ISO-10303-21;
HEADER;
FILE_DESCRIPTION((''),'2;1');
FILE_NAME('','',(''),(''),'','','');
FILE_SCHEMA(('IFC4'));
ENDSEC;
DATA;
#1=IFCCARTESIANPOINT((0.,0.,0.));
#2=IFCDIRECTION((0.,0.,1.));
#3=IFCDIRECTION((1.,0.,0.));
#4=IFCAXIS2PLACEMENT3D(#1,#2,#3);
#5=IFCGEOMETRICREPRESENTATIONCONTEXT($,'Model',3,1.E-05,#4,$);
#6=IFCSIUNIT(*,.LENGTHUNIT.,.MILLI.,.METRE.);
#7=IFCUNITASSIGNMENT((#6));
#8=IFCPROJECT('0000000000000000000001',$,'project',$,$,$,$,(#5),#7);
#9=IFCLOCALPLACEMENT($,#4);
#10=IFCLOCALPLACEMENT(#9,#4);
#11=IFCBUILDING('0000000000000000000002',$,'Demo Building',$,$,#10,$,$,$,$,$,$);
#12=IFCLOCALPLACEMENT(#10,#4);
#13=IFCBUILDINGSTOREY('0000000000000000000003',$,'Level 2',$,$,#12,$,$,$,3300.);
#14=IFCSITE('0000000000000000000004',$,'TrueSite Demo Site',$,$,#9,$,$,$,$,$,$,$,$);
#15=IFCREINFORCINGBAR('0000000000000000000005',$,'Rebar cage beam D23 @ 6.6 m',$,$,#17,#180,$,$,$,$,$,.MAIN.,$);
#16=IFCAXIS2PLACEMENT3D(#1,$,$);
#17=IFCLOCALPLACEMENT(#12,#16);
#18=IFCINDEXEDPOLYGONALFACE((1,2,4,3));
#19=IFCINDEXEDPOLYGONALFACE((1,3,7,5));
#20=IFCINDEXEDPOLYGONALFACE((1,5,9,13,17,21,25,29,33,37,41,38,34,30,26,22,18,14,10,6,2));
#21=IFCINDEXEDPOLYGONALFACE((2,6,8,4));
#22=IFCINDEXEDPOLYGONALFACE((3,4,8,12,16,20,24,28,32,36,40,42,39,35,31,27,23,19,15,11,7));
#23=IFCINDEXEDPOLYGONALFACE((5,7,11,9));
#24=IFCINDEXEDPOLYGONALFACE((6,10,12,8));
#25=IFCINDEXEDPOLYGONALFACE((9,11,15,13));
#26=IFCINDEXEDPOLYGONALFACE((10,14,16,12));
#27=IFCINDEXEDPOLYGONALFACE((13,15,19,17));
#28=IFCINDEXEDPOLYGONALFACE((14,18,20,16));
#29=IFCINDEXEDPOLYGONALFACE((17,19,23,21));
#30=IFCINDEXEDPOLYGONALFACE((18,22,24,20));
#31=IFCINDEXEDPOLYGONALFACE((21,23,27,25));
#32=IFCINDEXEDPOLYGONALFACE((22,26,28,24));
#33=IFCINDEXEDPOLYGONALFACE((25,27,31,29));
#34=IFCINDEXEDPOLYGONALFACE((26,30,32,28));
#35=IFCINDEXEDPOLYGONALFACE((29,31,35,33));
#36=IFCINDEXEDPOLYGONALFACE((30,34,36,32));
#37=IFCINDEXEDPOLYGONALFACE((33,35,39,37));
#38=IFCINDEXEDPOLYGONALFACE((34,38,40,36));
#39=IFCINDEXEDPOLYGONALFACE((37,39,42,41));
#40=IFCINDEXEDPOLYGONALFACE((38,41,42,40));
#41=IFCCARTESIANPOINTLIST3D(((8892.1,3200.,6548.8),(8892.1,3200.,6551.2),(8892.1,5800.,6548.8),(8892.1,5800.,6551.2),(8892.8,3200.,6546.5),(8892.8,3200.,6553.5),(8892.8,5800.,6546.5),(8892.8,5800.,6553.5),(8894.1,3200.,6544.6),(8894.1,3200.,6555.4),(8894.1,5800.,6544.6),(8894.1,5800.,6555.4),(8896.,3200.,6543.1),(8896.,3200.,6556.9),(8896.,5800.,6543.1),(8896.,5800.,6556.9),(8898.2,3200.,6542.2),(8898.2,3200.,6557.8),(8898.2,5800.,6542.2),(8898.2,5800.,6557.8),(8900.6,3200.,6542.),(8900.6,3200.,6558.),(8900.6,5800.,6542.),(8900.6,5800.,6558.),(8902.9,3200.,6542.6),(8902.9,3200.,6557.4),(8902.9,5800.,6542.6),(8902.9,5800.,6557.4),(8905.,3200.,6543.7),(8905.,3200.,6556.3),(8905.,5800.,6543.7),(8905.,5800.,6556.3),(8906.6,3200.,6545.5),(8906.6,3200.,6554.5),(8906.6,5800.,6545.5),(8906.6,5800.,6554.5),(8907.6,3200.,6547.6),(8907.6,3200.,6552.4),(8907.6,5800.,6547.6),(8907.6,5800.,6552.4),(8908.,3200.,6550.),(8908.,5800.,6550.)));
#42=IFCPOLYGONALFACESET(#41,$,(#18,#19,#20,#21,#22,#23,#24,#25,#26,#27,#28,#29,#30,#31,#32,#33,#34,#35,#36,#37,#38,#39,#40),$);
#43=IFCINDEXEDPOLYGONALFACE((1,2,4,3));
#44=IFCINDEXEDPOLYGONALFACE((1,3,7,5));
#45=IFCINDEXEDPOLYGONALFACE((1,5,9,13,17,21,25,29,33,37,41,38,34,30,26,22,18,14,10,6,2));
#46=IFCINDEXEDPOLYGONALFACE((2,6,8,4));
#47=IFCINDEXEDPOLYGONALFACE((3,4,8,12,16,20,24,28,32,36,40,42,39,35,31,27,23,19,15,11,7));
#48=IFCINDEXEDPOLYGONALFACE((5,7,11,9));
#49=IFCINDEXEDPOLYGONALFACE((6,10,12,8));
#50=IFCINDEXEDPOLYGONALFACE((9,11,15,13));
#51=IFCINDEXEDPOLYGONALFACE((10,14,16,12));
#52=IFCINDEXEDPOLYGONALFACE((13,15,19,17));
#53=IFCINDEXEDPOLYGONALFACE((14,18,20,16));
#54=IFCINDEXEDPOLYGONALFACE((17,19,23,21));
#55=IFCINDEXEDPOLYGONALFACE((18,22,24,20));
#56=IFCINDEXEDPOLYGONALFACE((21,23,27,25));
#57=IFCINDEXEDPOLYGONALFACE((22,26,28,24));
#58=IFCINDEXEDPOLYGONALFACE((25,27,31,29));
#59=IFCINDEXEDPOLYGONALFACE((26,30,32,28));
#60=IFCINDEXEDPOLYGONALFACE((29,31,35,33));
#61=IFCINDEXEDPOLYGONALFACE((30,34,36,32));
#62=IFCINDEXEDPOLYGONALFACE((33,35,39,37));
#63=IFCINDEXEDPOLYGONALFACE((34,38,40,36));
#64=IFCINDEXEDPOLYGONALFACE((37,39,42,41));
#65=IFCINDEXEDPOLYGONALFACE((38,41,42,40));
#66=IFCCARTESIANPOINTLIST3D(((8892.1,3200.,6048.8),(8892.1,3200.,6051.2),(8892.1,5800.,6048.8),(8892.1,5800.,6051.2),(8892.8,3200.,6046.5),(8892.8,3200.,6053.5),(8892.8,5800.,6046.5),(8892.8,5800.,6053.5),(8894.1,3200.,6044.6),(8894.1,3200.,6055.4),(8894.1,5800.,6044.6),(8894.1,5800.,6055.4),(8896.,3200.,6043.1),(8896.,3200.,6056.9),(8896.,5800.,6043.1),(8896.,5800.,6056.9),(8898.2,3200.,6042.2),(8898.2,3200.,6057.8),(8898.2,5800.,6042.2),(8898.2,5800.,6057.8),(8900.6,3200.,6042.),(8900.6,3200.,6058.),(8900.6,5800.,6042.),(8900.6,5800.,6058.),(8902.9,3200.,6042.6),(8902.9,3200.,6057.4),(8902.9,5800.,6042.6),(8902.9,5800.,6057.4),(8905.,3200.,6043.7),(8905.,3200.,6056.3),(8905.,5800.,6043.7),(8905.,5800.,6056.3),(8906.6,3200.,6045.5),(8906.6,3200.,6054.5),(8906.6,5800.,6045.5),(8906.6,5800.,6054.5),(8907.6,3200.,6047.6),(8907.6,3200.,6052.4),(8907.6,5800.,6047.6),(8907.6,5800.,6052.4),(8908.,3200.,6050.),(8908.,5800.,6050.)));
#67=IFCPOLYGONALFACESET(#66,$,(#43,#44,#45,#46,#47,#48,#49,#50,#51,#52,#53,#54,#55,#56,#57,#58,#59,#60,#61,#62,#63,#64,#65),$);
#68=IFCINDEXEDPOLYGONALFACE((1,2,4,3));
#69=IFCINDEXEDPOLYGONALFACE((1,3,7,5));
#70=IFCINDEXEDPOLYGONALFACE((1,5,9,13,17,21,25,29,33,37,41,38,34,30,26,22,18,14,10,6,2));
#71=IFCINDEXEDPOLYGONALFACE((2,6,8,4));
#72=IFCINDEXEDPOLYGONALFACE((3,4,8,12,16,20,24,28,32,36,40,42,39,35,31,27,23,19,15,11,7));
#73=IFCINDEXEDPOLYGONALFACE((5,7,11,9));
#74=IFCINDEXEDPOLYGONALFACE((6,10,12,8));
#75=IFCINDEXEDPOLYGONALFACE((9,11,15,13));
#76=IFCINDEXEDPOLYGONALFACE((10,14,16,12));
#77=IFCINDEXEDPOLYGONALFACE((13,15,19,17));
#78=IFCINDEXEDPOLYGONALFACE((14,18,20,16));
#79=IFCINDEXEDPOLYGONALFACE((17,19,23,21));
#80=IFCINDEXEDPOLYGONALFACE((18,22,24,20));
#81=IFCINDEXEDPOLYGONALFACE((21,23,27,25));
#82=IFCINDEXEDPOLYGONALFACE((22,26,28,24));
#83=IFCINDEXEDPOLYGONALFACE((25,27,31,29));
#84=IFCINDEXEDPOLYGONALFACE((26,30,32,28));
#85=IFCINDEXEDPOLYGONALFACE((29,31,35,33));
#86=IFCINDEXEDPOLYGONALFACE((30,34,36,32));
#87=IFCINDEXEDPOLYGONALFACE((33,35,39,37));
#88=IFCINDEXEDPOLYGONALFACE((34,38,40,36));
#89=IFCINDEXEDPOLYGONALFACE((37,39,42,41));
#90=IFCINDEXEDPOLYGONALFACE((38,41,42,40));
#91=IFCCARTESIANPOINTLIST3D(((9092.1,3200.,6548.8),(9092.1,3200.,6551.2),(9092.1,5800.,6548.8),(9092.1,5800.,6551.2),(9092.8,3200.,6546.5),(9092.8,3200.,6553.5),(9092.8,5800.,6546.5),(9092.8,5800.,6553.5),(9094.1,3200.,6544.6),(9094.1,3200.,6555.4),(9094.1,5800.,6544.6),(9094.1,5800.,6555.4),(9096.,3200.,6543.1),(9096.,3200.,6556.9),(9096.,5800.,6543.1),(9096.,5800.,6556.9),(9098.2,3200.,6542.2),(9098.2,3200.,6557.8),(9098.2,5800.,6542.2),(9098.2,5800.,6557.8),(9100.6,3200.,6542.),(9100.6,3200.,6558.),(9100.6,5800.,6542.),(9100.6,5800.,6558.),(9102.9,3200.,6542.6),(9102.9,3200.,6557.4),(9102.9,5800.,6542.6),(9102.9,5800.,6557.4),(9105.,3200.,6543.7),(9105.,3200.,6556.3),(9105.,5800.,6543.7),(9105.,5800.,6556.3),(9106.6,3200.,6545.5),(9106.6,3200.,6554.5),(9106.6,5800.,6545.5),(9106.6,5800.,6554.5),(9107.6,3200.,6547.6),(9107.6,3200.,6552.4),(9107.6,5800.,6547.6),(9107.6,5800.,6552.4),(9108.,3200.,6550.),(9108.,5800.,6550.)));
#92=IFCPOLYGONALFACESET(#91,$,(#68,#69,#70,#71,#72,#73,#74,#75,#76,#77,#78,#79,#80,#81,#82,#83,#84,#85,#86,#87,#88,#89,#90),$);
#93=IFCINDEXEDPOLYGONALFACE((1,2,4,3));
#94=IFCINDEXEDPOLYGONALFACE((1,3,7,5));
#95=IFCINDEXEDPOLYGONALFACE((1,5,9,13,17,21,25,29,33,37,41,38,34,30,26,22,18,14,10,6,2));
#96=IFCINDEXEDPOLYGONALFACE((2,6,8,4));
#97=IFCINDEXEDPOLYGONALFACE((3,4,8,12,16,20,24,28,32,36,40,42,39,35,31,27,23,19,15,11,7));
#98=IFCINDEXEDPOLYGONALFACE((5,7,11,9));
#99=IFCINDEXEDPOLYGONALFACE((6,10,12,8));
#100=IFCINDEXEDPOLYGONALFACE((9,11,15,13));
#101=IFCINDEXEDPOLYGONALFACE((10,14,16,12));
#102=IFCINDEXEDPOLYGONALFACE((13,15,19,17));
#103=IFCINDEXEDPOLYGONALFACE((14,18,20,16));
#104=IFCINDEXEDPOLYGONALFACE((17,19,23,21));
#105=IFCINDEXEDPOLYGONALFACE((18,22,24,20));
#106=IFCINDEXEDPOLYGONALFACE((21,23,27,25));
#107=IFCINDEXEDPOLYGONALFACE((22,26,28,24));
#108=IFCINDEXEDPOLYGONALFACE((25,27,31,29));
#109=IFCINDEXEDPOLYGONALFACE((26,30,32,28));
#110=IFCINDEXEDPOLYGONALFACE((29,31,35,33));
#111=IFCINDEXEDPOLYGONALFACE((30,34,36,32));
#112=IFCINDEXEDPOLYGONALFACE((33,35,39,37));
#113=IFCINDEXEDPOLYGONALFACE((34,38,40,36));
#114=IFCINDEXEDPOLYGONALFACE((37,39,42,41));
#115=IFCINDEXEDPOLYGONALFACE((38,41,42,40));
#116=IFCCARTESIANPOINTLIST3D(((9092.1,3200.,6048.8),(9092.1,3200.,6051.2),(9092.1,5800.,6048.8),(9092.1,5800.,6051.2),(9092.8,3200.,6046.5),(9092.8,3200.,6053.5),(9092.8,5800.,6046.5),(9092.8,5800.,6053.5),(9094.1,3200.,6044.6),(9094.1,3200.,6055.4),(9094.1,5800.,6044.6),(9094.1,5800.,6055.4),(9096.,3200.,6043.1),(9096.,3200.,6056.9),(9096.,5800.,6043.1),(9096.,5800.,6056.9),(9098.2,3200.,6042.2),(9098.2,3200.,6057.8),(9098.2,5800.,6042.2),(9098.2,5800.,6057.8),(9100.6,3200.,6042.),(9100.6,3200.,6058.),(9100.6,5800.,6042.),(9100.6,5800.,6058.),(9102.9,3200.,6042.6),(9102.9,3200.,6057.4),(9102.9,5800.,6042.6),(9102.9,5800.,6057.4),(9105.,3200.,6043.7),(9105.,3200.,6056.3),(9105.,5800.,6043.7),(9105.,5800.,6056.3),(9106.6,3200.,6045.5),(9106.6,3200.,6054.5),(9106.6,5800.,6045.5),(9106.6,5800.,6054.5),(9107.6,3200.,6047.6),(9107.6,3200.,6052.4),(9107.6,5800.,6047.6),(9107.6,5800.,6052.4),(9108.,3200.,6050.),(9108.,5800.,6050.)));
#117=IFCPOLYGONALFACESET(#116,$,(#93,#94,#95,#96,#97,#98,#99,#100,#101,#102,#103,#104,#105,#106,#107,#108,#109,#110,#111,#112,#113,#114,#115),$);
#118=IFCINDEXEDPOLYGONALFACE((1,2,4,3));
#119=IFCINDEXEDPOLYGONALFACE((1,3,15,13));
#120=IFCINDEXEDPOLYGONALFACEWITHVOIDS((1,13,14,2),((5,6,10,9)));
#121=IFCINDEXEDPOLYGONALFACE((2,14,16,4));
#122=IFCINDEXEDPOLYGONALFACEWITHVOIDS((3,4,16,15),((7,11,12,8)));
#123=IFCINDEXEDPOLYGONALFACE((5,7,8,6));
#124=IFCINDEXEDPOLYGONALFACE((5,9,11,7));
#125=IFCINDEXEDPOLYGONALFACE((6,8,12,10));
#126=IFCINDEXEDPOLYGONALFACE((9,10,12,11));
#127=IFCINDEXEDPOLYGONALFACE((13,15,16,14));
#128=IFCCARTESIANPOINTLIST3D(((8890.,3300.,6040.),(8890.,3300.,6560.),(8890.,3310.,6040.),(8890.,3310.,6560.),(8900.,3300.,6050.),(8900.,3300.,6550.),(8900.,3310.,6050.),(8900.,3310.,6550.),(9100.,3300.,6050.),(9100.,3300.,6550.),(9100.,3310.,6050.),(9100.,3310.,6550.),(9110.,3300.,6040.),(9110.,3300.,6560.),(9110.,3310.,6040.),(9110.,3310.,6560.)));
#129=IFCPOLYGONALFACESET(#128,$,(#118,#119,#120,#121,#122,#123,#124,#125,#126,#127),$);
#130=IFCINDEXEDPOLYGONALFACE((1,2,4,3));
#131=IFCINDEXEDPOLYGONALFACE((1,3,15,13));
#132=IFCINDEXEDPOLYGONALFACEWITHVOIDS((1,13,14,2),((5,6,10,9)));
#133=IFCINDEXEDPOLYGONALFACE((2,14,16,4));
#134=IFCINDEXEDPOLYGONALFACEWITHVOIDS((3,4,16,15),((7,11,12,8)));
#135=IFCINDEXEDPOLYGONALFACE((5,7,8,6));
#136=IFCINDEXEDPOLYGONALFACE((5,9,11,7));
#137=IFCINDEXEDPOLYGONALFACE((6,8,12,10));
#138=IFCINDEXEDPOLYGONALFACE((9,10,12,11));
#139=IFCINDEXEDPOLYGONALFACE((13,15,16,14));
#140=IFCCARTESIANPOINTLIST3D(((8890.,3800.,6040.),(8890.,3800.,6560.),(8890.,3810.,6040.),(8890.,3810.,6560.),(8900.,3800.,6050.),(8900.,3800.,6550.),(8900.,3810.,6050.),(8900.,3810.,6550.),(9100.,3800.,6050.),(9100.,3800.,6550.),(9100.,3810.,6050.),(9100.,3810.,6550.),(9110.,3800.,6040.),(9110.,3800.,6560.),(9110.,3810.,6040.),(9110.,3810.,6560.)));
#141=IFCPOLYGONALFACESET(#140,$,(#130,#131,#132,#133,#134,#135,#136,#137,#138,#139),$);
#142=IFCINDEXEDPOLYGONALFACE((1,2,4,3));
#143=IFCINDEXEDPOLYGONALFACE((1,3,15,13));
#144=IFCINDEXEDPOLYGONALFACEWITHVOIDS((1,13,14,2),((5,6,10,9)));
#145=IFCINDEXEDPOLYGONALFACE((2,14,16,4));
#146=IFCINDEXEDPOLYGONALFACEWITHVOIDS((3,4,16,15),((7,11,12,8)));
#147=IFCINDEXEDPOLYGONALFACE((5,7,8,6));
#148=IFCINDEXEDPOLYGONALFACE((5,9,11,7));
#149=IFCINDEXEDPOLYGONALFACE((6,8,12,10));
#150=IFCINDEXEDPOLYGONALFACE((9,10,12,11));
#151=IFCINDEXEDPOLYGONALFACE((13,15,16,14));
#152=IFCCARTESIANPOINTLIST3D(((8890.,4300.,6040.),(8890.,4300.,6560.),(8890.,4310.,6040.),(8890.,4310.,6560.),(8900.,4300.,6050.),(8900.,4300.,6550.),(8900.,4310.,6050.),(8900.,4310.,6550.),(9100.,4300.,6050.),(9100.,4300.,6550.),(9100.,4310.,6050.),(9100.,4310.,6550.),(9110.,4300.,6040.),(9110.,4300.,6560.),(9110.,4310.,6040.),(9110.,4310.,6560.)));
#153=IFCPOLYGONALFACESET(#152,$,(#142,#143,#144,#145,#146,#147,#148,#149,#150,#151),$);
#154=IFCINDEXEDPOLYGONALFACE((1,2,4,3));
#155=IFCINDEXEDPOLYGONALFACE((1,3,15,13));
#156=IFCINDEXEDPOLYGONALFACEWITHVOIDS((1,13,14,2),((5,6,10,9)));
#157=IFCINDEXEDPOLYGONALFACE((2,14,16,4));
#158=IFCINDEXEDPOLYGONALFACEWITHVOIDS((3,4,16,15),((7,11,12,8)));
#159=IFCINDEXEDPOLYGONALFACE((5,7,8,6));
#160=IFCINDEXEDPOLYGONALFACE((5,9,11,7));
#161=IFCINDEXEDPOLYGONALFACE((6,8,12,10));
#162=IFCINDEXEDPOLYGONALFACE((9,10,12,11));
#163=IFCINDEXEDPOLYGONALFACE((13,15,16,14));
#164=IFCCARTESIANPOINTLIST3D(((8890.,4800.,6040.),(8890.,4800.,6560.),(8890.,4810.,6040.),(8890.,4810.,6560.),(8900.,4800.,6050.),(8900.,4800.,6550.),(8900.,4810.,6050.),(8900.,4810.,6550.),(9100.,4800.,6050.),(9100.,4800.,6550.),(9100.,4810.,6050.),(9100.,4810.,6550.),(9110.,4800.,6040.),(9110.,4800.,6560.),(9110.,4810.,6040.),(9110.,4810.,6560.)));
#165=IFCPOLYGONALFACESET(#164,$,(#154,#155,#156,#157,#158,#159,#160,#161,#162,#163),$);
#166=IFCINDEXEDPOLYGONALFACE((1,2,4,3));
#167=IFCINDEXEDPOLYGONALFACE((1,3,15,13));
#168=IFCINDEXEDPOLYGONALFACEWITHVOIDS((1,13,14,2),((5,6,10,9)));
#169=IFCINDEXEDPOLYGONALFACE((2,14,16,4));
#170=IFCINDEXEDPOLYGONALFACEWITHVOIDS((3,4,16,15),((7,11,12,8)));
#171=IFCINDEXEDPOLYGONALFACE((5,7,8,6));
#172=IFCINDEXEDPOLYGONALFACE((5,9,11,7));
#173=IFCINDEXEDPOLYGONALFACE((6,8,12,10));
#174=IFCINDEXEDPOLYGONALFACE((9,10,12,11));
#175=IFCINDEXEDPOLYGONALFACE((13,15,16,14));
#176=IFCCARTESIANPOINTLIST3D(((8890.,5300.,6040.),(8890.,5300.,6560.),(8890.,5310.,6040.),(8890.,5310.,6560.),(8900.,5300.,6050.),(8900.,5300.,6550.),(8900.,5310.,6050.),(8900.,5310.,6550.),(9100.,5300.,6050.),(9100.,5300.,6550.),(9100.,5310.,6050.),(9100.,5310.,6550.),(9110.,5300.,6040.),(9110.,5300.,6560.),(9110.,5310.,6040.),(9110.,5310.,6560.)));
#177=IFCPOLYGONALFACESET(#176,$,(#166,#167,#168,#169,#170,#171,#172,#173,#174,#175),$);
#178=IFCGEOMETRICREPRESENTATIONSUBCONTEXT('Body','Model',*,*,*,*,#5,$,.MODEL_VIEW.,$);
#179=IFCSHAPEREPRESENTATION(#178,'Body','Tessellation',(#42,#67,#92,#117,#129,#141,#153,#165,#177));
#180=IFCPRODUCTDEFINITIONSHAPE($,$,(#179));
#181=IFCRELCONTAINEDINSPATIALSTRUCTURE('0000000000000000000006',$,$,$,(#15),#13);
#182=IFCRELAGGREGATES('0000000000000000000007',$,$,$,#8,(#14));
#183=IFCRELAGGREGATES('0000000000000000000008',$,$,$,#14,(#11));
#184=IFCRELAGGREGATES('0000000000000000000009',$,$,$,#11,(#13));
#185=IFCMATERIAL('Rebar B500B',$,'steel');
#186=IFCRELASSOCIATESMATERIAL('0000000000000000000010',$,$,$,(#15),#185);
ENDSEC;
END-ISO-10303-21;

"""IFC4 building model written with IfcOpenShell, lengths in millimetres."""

from ifc_helpers import new_model, si_unit, frame, origin_with_axes, place, context, subcontext, project, spatial, hollow_rectangle, circle, extrude, material, element, save


model = new_model("IFC4")

# Units and contexts
model_context = context("Model", 3, precision=1e-05, world=origin_with_axes())
body_context = subcontext(model_context, "Body", "Model", "MODEL_VIEW")
ifc_project = project(units=[si_unit("LENGTHUNIT", "METRE", prefix="MILLI")], contexts=[model_context])

# Site, building, storey
site_placement = place(None, origin_with_axes())
site = spatial("IfcSite", under=ifc_project, at=site_placement, Name="TrueSite Demo Site")
building_placement = place(site_placement, origin_with_axes())
building = spatial("IfcBuilding", under=site, at=building_placement, Name="Demo Building")
storey_placement = place(building_placement, origin_with_axes())
storey = spatial("IfcBuildingStorey", under=building, at=storey_placement, Name="Level 2", Elevation=3300.0)

# Reinforcing bar
ifc_material_1 = material(Name="Rebar B500B", Category="steel")
for number, where, z_axis, x_axis, name in (
    (1, (9000.0, 3200.0, 6300.0), (0.0, 1.0, 0.0), (1.0, 0.0, 0.0), "Rebar cage beam D23 @ 6.6 m"),
):
    element("IfcReinforcingBar", number, at=place(storey_placement, frame(where, z_axis=z_axis, x_axis=x_axis)), inside=storey, material=ifc_material_1, Name=name, PredefinedType="MAIN", context=body_context, shape_type="SweptSolid", body=[
        extrude(circle(Radius=8.0), frame((-100.0, -250.0, 0.0)), (0.0, 0.0, 1.0), 2600.0),
        extrude(circle(Radius=8.0), frame((-100.0, 250.0, 0.0)), (0.0, 0.0, 1.0), 2600.0),
        extrude(circle(Radius=8.0), frame((100.0, -250.0, 0.0)), (0.0, 0.0, 1.0), 2600.0),
        extrude(circle(Radius=8.0), frame((100.0, 250.0, 0.0)), (0.0, 0.0, 1.0), 2600.0),
        extrude(hollow_rectangle(XDim=220.0, YDim=520.0, WallThickness=10.0), frame((0.0, 0.0, 100.0)), (0.0, 0.0, 1.0), 10.0),
        extrude(hollow_rectangle(XDim=220.0, YDim=520.0, WallThickness=10.0), frame((0.0, 0.0, 600.0)), (0.0, 0.0, 1.0), 10.0),
        extrude(hollow_rectangle(XDim=220.0, YDim=520.0, WallThickness=10.0), frame((0.0, 0.0, 1100.0)), (0.0, 0.0, 1.0), 10.0),
        extrude(hollow_rectangle(XDim=220.0, YDim=520.0, WallThickness=10.0), frame((0.0, 0.0, 1600.0)), (0.0, 0.0, 1.0), 10.0),
        extrude(hollow_rectangle(XDim=220.0, YDim=520.0, WallThickness=10.0), frame((0.0, 0.0, 2100.0)), (0.0, 0.0, 1.0), 10.0),
    ])

save(model, "model.ifc")
